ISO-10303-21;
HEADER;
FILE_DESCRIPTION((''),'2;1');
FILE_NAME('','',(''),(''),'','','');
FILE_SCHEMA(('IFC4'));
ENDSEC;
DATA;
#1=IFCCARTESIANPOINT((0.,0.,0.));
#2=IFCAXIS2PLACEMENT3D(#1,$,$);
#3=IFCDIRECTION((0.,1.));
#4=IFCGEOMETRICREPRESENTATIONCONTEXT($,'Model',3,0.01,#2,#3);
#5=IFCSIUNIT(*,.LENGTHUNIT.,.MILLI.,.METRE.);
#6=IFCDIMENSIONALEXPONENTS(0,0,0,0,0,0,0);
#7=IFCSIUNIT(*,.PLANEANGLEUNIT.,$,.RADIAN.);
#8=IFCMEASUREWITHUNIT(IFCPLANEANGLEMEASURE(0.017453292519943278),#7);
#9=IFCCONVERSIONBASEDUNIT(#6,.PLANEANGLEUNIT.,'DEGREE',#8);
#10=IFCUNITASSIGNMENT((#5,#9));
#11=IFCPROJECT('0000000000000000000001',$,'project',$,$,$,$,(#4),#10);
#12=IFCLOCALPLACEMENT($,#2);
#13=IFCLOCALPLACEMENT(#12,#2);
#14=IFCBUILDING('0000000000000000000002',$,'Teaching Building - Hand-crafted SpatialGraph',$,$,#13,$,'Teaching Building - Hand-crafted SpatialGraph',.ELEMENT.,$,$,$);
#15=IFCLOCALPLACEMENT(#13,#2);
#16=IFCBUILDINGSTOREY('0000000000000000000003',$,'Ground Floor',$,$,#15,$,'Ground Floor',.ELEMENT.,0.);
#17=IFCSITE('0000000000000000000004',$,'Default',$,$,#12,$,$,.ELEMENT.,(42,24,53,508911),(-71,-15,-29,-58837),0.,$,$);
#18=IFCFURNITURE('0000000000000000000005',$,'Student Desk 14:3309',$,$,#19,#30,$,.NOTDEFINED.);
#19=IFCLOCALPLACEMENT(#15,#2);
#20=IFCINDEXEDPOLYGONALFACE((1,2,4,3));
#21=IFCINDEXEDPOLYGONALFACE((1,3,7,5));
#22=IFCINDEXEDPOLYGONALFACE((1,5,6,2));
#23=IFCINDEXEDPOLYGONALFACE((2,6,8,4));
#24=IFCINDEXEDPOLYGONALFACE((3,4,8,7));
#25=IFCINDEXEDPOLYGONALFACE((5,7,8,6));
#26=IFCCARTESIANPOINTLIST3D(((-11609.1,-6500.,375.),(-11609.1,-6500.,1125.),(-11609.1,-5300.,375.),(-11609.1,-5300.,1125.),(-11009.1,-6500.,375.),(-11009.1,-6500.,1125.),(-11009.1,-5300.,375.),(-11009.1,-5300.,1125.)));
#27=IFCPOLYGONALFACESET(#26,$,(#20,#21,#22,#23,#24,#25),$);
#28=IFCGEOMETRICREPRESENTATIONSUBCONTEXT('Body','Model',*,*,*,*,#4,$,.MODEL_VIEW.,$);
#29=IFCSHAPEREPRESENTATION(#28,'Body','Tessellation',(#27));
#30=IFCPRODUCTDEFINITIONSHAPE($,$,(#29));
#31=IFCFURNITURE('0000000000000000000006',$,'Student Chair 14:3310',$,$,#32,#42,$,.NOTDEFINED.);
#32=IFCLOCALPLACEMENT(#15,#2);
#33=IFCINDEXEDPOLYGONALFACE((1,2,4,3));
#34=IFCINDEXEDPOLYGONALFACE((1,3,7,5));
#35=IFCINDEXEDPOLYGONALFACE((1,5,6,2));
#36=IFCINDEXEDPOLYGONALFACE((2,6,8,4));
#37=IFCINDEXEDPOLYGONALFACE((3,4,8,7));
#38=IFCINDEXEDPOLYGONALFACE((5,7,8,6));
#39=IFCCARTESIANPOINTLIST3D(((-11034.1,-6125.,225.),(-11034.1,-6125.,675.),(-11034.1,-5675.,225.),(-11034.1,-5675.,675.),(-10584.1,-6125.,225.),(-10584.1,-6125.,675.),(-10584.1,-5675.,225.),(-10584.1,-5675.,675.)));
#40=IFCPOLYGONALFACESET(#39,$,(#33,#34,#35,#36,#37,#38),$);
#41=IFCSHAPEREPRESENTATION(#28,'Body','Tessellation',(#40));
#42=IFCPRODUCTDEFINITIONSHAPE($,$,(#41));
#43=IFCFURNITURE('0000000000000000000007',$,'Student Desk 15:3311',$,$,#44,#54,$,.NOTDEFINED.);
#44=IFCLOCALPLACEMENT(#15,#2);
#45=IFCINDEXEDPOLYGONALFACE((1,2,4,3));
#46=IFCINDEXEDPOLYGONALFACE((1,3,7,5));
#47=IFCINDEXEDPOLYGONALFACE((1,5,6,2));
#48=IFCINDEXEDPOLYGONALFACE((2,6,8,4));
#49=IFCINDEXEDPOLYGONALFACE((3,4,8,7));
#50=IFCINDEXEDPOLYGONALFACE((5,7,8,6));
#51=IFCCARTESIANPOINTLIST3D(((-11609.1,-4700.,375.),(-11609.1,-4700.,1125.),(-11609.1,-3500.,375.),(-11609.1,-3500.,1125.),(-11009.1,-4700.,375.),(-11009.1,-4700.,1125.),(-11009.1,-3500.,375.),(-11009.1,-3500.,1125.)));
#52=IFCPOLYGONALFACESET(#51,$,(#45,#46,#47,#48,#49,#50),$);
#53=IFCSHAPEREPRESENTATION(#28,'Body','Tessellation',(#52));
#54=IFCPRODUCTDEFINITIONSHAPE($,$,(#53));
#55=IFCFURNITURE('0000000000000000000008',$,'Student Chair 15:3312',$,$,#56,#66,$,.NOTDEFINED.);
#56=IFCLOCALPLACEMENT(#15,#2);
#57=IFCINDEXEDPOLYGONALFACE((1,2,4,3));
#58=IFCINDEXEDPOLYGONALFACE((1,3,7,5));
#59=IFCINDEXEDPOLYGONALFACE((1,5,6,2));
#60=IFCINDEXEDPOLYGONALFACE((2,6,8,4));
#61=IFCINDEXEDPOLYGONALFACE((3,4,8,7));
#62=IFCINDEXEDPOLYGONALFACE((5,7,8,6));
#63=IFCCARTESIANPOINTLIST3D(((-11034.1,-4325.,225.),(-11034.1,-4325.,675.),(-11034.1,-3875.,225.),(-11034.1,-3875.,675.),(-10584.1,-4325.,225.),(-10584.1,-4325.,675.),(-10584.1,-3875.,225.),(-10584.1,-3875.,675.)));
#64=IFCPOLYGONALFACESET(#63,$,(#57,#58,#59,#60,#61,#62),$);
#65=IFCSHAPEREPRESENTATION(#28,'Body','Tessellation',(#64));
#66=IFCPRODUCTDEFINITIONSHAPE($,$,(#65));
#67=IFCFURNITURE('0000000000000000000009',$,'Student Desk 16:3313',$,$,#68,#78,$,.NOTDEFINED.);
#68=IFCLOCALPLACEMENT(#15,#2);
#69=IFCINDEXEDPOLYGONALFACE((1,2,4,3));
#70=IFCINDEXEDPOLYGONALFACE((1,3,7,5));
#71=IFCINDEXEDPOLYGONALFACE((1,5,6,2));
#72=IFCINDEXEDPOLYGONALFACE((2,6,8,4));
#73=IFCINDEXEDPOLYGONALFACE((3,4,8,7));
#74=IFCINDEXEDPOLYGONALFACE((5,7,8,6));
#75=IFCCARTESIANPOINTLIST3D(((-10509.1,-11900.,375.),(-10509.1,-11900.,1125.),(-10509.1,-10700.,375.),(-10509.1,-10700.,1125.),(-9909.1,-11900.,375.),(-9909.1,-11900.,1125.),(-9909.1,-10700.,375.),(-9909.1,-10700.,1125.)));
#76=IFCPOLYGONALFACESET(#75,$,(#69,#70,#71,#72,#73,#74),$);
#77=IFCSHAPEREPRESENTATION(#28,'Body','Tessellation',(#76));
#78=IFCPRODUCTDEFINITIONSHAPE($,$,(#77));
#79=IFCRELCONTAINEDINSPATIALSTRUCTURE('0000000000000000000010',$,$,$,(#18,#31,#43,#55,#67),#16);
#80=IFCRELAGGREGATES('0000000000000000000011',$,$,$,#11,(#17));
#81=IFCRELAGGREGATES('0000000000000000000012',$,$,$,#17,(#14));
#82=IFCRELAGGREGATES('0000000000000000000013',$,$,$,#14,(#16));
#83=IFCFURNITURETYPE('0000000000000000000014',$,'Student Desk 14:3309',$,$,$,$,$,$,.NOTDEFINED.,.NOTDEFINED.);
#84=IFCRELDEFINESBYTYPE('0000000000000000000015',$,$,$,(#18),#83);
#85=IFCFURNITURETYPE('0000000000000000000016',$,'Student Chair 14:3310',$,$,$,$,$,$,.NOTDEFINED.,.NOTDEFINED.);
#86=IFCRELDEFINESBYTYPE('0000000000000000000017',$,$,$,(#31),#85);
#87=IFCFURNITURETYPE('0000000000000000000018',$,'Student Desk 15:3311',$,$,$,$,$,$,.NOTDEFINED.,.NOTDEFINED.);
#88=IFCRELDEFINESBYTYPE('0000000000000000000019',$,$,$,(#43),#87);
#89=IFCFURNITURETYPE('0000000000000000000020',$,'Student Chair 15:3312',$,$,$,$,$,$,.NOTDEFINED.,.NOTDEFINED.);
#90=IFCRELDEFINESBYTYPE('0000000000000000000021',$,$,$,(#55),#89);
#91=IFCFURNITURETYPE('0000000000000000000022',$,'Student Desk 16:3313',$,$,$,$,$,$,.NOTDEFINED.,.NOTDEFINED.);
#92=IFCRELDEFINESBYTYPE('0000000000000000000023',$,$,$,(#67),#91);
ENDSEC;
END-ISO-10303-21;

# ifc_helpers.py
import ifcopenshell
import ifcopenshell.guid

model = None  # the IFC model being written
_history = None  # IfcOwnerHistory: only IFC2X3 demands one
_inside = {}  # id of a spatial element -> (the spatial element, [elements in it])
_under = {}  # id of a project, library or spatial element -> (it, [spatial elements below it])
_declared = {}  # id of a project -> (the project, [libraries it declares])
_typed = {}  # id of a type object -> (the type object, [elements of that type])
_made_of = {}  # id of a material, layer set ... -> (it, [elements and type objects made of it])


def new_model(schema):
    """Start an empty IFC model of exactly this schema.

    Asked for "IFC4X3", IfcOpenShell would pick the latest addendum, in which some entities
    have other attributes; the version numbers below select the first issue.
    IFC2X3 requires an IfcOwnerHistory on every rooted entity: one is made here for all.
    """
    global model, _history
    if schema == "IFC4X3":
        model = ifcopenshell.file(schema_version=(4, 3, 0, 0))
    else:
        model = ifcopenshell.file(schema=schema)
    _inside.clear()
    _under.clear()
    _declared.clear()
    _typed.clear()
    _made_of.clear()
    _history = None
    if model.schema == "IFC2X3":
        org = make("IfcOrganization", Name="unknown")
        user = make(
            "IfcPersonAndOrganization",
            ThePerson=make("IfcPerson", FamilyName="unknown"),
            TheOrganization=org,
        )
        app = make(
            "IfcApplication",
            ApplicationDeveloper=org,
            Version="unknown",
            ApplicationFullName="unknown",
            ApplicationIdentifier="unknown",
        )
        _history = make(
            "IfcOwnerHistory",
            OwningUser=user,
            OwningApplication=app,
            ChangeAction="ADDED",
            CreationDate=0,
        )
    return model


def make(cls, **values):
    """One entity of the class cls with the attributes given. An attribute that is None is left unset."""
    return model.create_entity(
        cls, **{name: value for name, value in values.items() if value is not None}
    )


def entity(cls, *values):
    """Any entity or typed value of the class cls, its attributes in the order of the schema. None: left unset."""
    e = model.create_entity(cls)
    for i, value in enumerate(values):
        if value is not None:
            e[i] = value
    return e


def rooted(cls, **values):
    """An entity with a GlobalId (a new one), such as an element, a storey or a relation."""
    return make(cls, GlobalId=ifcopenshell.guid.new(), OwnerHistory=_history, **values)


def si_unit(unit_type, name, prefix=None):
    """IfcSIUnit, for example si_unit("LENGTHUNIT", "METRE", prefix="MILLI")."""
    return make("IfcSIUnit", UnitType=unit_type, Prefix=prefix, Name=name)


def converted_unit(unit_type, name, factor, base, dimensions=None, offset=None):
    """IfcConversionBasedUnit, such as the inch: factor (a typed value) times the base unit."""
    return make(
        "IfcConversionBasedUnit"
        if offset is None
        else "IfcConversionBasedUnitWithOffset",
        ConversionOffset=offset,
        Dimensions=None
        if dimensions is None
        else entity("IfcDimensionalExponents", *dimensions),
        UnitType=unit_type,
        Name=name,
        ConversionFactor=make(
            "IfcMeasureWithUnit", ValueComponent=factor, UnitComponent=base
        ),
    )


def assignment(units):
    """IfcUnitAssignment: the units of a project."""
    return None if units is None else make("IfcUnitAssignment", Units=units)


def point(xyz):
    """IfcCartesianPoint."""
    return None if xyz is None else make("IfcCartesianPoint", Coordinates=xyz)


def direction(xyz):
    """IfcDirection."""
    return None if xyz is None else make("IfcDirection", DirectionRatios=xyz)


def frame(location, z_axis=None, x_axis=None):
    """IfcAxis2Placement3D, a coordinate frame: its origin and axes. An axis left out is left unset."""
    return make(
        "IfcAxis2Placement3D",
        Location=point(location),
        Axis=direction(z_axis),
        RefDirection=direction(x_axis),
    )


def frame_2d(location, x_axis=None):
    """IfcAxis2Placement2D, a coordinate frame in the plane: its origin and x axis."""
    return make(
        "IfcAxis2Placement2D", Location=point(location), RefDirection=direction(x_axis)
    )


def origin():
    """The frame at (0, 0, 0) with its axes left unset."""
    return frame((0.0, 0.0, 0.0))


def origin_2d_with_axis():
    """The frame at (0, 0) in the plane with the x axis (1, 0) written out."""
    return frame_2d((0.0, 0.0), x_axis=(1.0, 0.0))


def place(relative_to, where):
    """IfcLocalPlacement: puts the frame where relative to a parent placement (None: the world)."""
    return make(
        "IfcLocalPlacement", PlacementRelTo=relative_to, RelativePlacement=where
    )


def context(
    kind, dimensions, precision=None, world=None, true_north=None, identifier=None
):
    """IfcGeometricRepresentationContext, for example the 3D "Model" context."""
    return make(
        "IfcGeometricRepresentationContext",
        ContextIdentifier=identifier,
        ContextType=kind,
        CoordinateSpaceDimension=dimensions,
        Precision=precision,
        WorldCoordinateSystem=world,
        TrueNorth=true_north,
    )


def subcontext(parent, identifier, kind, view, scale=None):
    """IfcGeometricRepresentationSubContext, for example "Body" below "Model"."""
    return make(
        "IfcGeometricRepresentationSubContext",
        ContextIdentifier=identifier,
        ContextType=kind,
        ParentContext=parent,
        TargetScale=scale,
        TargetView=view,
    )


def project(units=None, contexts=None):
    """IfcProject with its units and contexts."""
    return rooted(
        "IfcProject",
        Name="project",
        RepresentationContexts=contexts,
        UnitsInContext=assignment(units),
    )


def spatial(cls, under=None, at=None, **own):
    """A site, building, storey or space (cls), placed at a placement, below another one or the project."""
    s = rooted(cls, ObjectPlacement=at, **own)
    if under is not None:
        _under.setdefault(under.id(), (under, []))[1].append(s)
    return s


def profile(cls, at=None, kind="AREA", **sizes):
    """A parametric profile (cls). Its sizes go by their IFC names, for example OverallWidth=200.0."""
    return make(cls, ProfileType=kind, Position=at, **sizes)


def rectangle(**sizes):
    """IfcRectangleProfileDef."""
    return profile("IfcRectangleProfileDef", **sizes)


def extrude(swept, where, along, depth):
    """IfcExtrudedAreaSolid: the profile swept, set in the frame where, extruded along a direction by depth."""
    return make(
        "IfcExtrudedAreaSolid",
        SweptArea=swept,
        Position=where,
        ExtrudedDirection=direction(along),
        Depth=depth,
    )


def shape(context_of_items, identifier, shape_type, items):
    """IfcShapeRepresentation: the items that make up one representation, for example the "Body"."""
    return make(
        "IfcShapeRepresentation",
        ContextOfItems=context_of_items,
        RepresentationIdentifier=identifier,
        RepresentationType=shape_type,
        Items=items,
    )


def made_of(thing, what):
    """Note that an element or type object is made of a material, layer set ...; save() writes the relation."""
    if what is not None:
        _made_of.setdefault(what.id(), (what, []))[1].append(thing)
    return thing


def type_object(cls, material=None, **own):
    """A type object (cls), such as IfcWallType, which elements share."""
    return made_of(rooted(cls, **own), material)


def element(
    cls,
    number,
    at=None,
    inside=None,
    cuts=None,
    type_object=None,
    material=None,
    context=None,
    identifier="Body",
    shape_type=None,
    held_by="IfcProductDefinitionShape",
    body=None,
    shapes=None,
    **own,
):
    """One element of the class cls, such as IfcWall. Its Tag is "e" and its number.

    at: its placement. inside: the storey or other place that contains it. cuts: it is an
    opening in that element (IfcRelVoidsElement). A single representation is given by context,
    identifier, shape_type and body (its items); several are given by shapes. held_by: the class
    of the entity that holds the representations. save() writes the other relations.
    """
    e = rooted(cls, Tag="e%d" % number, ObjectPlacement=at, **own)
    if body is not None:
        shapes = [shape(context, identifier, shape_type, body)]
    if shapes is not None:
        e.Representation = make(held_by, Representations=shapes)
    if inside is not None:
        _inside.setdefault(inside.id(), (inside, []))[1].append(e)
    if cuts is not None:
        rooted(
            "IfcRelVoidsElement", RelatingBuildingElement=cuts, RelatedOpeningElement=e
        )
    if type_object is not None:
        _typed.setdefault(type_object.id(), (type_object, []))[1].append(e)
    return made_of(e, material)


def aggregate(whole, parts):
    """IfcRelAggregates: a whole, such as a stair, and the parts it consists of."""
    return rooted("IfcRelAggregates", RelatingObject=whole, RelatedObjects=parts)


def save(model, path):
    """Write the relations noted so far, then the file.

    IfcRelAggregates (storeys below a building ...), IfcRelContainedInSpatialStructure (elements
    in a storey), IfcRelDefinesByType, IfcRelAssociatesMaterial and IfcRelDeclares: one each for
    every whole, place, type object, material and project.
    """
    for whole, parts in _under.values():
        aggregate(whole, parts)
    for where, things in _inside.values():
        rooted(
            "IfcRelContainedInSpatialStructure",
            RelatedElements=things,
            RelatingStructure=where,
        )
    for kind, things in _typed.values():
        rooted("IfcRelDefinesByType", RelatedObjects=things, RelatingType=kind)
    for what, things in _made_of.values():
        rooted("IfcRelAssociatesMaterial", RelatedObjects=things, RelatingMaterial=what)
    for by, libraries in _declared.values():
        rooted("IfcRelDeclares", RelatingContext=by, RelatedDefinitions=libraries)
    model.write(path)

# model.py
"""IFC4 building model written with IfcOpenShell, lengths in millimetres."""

from ifc_helpers import new_model, entity, si_unit, converted_unit, direction, frame, origin, origin_2d_with_axis, place, context, subcontext, project, spatial, rectangle, extrude, type_object, element, save


model = new_model("IFC4")

# Units and contexts
model_context = context("Model", 3, precision=0.01, world=origin(), true_north=direction((0.0, 1.0)))
body_context = subcontext(model_context, "Body", "Model", "MODEL_VIEW")
ifc_project = project(units=[si_unit("LENGTHUNIT", "METRE", prefix="MILLI"), converted_unit("PLANEANGLEUNIT", "DEGREE", entity("IfcPlaneAngleMeasure", 0.017453292519943278), si_unit("PLANEANGLEUNIT", "RADIAN"), dimensions=[0, 0, 0, 0, 0, 0, 0])], contexts=[model_context])

# Site, building, storey
site_placement = place(None, origin())
site = spatial("IfcSite", under=ifc_project, at=site_placement, Name="Default", CompositionType="ELEMENT", RefLatitude=(42, 24, 53, 508911), RefLongitude=(-71, -15, -29, -58837), RefElevation=0.0)
building_placement = place(site_placement, origin())
building = spatial("IfcBuilding", under=site, at=building_placement, Name="Teaching Building - Hand-crafted SpatialGraph", LongName="Teaching Building - Hand-crafted SpatialGraph", CompositionType="ELEMENT")
storey_placement = place(building_placement, origin())
storey = spatial("IfcBuildingStorey", under=building, at=storey_placement, Name="Ground Floor", LongName="Ground Floor", CompositionType="ELEMENT", Elevation=0.0)

# Furniture
furniture_type_1 = type_object("IfcFurnitureType", Name="Student Desk 14:3309", PredefinedType="NOTDEFINED")
furniture_1_placement = place(storey_placement, origin())
element("IfcFurniture", 1, at=furniture_1_placement, inside=storey, type_object=furniture_type_1, Name="Student Desk 14:3309", PredefinedType="NOTDEFINED", context=body_context, shape_type="SweptSolid", body=[
    extrude(rectangle(XDim=1200.0, YDim=600.0, at=origin_2d_with_axis()), frame((-11309.1, -5900.0, 375.0), z_axis=(0.0, 0.0, 1.0), x_axis=(0.0, 1.0, 0.0)), (0.0, 0.0, 1.0), 750.0),
])
furniture_type_2 = type_object("IfcFurnitureType", Name="Student Chair 14:3310", PredefinedType="NOTDEFINED")
furniture_2_placement = place(storey_placement, origin())
element("IfcFurniture", 2, at=furniture_2_placement, inside=storey, type_object=furniture_type_2, Name="Student Chair 14:3310", PredefinedType="NOTDEFINED", context=body_context, shape_type="SweptSolid", body=[
    extrude(rectangle(XDim=450.0, YDim=450.0, at=origin_2d_with_axis()), frame((-10809.1, -5900.0, 225.0)), (0.0, 0.0, 1.0), 450.0),
])
furniture_type_3 = type_object("IfcFurnitureType", Name="Student Desk 15:3311", PredefinedType="NOTDEFINED")
furniture_3_placement = place(storey_placement, origin())
element("IfcFurniture", 3, at=furniture_3_placement, inside=storey, type_object=furniture_type_3, Name="Student Desk 15:3311", PredefinedType="NOTDEFINED", context=body_context, shape_type="SweptSolid", body=[
    extrude(rectangle(XDim=1200.0, YDim=600.0, at=origin_2d_with_axis()), frame((-11309.1, -4100.0, 375.0), z_axis=(0.0, 0.0, 1.0), x_axis=(0.0, 1.0, 0.0)), (0.0, 0.0, 1.0), 750.0),
])
furniture_type_4 = type_object("IfcFurnitureType", Name="Student Chair 15:3312", PredefinedType="NOTDEFINED")
furniture_4_placement = place(storey_placement, origin())
element("IfcFurniture", 4, at=furniture_4_placement, inside=storey, type_object=furniture_type_4, Name="Student Chair 15:3312", PredefinedType="NOTDEFINED", context=body_context, shape_type="SweptSolid", body=[
    extrude(rectangle(XDim=450.0, YDim=450.0, at=origin_2d_with_axis()), frame((-10809.1, -4100.0, 225.0)), (0.0, 0.0, 1.0), 450.0),
])
furniture_type_5 = type_object("IfcFurnitureType", Name="Student Desk 16:3313", PredefinedType="NOTDEFINED")
furniture_5_placement = place(storey_placement, origin())
element("IfcFurniture", 5, at=furniture_5_placement, inside=storey, type_object=furniture_type_5, Name="Student Desk 16:3313", PredefinedType="NOTDEFINED", context=body_context, shape_type="SweptSolid", body=[
    extrude(rectangle(XDim=1200.0, YDim=600.0, at=origin_2d_with_axis()), frame((-10209.1, -11300.0, 375.0), z_axis=(0.0, 0.0, 1.0), x_axis=(0.0, 1.0, 0.0)), (0.0, 0.0, 1.0), 750.0),
])

save(model, "model.ifc")
